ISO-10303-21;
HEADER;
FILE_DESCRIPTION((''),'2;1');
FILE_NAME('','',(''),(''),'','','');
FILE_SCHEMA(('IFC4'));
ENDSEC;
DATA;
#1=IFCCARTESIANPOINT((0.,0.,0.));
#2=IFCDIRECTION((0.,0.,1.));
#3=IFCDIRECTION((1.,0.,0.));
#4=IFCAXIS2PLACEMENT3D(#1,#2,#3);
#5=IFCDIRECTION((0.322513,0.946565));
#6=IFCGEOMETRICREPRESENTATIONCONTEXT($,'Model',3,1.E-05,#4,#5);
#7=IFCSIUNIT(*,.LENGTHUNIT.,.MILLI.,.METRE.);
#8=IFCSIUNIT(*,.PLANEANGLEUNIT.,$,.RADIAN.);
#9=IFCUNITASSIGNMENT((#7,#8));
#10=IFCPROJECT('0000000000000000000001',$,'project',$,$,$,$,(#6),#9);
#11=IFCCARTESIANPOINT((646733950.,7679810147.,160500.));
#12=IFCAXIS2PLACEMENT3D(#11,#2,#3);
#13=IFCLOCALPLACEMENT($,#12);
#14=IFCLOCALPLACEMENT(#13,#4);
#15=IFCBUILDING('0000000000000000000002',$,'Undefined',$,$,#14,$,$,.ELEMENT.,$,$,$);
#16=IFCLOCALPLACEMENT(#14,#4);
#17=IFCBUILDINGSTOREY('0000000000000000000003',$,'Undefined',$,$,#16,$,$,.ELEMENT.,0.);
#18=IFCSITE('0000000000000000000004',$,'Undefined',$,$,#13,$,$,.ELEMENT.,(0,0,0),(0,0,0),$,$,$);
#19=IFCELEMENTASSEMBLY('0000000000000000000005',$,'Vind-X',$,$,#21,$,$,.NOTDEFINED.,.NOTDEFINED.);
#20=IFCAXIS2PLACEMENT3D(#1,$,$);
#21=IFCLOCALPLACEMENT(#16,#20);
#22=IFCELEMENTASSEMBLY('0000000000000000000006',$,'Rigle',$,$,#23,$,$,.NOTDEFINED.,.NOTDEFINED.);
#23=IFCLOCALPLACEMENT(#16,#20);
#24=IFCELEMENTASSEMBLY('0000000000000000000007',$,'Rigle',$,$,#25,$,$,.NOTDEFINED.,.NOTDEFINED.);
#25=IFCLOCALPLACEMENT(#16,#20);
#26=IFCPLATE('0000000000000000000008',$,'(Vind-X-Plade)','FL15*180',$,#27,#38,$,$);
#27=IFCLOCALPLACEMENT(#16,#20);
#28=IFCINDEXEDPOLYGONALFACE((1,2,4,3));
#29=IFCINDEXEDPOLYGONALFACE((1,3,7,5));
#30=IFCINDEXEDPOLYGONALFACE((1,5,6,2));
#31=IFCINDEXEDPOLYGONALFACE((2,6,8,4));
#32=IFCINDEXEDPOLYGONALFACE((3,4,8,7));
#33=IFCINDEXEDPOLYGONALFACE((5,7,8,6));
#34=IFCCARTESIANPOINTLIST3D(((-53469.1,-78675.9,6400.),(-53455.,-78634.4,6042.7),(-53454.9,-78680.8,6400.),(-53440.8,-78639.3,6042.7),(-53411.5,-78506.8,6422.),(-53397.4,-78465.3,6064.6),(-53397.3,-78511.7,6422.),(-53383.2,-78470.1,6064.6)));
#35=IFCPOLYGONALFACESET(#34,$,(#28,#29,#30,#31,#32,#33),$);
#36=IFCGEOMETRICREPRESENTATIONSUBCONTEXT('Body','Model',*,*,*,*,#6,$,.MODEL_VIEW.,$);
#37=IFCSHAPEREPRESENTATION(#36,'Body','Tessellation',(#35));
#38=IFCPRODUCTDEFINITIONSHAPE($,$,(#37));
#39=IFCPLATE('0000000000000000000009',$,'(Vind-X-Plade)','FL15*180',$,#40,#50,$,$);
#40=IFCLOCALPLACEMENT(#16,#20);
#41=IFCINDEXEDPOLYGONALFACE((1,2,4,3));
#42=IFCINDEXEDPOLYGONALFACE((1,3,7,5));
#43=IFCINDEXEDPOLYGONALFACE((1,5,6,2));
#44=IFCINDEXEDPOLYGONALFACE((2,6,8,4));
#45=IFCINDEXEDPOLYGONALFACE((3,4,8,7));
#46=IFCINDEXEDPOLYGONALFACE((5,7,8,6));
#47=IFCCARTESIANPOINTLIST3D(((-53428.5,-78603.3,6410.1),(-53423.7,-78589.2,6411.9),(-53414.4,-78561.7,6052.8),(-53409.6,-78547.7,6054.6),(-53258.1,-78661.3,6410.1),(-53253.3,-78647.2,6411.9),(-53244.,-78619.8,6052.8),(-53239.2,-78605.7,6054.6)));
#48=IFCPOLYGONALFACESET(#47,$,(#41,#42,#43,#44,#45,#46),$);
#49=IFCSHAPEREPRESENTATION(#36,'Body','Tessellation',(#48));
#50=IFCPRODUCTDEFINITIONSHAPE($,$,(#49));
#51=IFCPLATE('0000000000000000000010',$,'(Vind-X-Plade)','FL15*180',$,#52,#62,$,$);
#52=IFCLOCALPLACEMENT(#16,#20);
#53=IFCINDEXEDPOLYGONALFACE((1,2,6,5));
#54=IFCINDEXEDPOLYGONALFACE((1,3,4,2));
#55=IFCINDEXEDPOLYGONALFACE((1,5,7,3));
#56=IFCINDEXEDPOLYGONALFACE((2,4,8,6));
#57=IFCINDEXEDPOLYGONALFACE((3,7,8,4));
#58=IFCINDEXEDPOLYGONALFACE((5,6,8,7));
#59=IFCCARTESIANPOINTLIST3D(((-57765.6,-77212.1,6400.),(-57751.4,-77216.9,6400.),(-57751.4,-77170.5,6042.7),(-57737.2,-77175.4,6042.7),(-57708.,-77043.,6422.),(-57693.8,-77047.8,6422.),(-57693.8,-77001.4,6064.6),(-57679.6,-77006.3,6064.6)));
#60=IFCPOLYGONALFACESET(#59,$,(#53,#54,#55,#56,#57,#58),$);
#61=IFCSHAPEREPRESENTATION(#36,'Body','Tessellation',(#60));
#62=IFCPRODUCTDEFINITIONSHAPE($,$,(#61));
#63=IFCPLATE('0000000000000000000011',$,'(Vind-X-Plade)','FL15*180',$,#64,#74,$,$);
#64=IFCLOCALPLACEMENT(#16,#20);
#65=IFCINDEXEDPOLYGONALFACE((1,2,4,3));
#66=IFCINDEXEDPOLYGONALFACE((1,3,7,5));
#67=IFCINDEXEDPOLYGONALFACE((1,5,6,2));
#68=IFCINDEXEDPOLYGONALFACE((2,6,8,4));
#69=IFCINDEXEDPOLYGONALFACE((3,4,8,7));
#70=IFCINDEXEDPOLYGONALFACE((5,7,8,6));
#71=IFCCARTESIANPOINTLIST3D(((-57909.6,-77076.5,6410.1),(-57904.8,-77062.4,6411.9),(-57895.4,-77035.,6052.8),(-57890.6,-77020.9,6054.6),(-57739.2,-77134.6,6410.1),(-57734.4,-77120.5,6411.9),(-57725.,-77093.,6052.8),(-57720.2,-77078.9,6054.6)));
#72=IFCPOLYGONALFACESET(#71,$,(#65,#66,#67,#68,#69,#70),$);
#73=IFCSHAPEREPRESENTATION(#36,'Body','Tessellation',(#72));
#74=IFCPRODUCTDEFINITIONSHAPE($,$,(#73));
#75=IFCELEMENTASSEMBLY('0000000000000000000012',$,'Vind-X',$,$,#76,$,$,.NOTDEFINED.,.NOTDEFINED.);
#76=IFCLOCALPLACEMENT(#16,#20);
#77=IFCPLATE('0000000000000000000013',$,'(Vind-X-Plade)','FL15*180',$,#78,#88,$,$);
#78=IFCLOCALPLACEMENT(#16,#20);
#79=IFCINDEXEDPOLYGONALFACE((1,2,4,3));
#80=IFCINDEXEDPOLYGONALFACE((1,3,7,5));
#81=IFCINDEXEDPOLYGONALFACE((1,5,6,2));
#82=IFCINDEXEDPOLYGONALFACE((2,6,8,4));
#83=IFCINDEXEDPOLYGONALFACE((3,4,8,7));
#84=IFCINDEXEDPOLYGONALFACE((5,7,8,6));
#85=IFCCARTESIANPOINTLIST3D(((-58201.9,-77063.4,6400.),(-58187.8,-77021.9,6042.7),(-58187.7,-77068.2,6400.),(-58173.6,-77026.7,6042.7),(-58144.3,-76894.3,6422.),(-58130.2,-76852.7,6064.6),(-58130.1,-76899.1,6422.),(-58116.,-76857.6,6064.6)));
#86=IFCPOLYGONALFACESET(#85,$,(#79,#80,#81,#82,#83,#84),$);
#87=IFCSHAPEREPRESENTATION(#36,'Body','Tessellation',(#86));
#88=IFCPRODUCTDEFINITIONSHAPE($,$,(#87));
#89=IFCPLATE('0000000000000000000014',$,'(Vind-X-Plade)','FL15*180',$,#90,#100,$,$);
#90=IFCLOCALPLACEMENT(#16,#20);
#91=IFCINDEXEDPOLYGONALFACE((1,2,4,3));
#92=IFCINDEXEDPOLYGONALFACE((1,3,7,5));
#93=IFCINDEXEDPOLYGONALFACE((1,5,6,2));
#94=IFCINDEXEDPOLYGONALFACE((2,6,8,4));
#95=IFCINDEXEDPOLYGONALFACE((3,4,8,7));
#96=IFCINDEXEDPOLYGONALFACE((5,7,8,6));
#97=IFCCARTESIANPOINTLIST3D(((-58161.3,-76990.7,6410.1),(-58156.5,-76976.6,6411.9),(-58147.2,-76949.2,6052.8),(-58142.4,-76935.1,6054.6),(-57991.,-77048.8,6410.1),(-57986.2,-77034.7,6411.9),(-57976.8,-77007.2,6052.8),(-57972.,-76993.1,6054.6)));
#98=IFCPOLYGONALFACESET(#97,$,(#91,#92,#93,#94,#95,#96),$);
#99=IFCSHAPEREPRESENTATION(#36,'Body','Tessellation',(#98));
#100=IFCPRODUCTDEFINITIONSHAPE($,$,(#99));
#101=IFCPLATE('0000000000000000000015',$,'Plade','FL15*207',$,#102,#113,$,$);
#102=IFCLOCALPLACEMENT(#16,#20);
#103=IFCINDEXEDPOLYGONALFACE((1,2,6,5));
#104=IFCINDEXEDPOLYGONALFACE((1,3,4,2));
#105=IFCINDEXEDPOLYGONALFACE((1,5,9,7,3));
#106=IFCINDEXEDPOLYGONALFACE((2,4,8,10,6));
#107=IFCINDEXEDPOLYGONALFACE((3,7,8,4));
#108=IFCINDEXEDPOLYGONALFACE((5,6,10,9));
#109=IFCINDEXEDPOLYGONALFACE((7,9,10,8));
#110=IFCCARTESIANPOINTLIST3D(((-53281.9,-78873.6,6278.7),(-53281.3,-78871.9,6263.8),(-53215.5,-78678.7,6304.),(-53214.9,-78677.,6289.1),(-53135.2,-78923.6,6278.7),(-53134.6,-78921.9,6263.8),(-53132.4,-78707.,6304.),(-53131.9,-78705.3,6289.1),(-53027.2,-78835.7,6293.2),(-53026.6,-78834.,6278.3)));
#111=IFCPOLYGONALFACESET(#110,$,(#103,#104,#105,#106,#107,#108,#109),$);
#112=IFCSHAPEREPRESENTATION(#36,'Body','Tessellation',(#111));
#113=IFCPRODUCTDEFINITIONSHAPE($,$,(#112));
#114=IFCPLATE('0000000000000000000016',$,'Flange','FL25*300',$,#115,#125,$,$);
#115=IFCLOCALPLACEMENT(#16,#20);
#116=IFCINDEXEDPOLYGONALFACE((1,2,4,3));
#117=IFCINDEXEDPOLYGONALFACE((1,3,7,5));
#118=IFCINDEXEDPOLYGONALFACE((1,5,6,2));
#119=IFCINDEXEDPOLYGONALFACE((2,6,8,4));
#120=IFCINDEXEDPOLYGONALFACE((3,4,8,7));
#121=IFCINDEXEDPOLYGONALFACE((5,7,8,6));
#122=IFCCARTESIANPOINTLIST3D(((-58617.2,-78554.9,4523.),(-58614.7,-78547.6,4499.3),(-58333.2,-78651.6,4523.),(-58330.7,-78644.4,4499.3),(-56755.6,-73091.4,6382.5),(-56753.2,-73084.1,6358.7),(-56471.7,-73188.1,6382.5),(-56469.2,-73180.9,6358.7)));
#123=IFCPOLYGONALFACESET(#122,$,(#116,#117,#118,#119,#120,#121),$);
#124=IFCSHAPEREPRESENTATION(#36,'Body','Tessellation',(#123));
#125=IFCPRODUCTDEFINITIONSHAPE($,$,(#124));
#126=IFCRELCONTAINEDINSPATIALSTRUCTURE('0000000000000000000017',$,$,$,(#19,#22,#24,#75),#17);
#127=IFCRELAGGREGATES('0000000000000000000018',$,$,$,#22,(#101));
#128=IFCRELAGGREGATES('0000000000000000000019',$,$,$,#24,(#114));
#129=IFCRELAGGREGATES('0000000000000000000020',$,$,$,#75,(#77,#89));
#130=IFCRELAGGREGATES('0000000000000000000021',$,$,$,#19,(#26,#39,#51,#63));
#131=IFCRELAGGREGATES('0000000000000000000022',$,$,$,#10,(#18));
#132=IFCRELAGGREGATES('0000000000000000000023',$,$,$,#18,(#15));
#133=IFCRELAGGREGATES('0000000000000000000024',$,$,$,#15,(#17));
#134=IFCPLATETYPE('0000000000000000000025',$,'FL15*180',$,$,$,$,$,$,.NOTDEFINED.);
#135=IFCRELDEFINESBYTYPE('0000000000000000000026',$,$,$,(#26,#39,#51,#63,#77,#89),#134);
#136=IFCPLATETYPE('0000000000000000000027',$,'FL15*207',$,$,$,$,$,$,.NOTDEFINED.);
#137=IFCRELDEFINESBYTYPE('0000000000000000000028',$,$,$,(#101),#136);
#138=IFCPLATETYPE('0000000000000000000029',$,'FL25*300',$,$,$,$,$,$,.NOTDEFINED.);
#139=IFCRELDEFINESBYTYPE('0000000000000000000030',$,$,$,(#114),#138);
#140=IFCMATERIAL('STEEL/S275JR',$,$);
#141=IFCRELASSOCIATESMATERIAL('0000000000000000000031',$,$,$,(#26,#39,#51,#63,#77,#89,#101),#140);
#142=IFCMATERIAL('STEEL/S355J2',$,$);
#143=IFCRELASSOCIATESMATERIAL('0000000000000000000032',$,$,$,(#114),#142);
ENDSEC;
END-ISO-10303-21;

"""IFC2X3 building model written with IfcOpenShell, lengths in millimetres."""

from ifc_helpers import new_model, si_unit, direction, frame, origin_with_axes, place, context, subcontext, project, spatial, polyline, outline, extrude, clip, halfspace, material, type_object, element, aggregate, save


model = new_model("IFC2X3")

# Units and contexts
model_context = context("Model", 3, precision=1e-05, world=origin_with_axes(), true_north=direction((0.322513, 0.946565)))
body_context = subcontext(model_context, "Body", "Model", "MODEL_VIEW")
ifc_project = project(units=[si_unit("LENGTHUNIT", "METRE", prefix="MILLI"), si_unit("PLANEANGLEUNIT", "RADIAN")], contexts=[model_context])

# Site, building, storey
site_placement = place(None, frame((646733950.0, 7679810147.0, 160500.0), z_axis=(0.0, 0.0, 1.0), x_axis=(1.0, 0.0, 0.0)))
site = spatial("IfcSite", under=ifc_project, at=site_placement, Name="Undefined", CompositionType="ELEMENT", RefLatitude=(0, 0, 0), RefLongitude=(0, 0, 0))
building_placement = place(site_placement, origin_with_axes())
building = spatial("IfcBuilding", under=site, at=building_placement, Name="Undefined", CompositionType="ELEMENT")
storey_placement = place(building_placement, origin_with_axes())
storey = spatial("IfcBuildingStorey", under=building, at=storey_placement, Name="Undefined", CompositionType="ELEMENT", Elevation=0.0)

# Shared definitions
ifc_material_1 = material(Name="STEEL/S355J2")

# Element assembly
assembly_1_placement = place(storey_placement, origin_with_axes())
assembly_1 = element("IfcElementAssembly", 1, at=assembly_1_placement, inside=storey, Name="Vind-X", AssemblyPlace="NOTDEFINED", PredefinedType="NOTDEFINED")

# Shared definitions
ifc_material_2 = material(Name="STEEL/S275JR")

# Element assemblies
assembly_2_placement = place(storey_placement, origin_with_axes())
assembly_2 = element("IfcElementAssembly", 2, at=assembly_2_placement, inside=storey, Name="Rigle", AssemblyPlace="NOTDEFINED", PredefinedType="NOTDEFINED")
assembly_3_placement = place(storey_placement, origin_with_axes())
assembly_3 = element("IfcElementAssembly", 3, at=assembly_3_placement, inside=storey, Name="Rigle", AssemblyPlace="NOTDEFINED", PredefinedType="NOTDEFINED")

# Shared definitions
plate_type_1 = type_object("IfcPlateType", Name="FL15*180", PredefinedType="NOTDEFINED")

# Plates
plate_1_placement = place(assembly_1_placement, frame((-53404.4, -78509.3, 6422.0), z_axis=(0.946565, -0.322513, 0.0), x_axis=(-0.320109, -0.93951, -0.121869)))
plate_1 = element("IfcPlate", 4, at=plate_1_placement, type_object=plate_type_1, material=ifc_material_2, Name="(Vind-X-Plade)", Description="FL15*180", context=body_context, shape_type="SweptSolid", body=[
    extrude(outline(polyline([(0.0, 0.0), (180.0, 0.0), (180.0, 360.0), (0.0, 360.0), (0.0, 0.0)])), frame((0.0, 0.0, -7.5), z_axis=(0.0, 0.0, 1.0), x_axis=(1.0, 0.0, 0.0)), (0.0, 0.0, 1.0), 15.0),
])
plate_2_placement = place(assembly_1_placement, frame((-53241.6, -78612.8, 6053.7), z_axis=(-0.320109, -0.93951, -0.121869), x_axis=(-0.039304, -0.115357, 0.992546)))
plate_2 = element("IfcPlate", 5, at=plate_2_placement, type_object=plate_type_1, material=ifc_material_2, Name="(Vind-X-Plade)", Description="FL15*180", context=body_context, shape_type="SweptSolid", body=[
    extrude(outline(polyline([(0.0, 0.0), (360.0, 0.0), (360.0, 180.0), (0.0, 180.0), (0.0, 0.0)])), frame((0.0, 0.0, -7.5), z_axis=(0.0, 0.0, 1.0), x_axis=(1.0, 0.0, 0.0)), (0.0, 0.0, 1.0), 15.0),
])
plate_3_placement = place(assembly_1_placement, frame((-57758.5, -77214.5, 6400.0), z_axis=(-0.946565, 0.322513, 0.0), x_axis=(0.320109, 0.93951, 0.121869)))
plate_3 = element("IfcPlate", 6, at=plate_3_placement, type_object=plate_type_1, material=ifc_material_2, Name="(Vind-X-Plade)", Description="FL15*180", context=body_context, shape_type="SweptSolid", body=[
    extrude(outline(polyline([(0.0, 0.0), (180.0, 0.0), (180.0, 360.0), (0.0, 360.0), (0.0, 0.0)])), frame((0.0, 0.0, -7.5), z_axis=(0.0, 0.0, 1.0), x_axis=(1.0, 0.0, 0.0)), (0.0, 0.0, 1.0), 15.0),
])
plate_4_placement = place(assembly_1_placement, frame((-57893.0, -77027.9, 6053.7), z_axis=(0.320109, 0.93951, 0.121869), x_axis=(-0.039304, -0.115357, 0.992546)))
plate_4 = element("IfcPlate", 7, at=plate_4_placement, type_object=plate_type_1, material=ifc_material_2, Name="(Vind-X-Plade)", Description="FL15*180", context=body_context, shape_type="SweptSolid", body=[
    extrude(outline(polyline([(0.0, 0.0), (360.0, 0.0), (360.0, 180.0), (0.0, 180.0), (0.0, 0.0)])), frame((0.0, 0.0, -7.5), z_axis=(0.0, 0.0, 1.0), x_axis=(1.0, 0.0, 0.0)), (0.0, 0.0, 1.0), 15.0),
])

# Element assembly, plates
assembly_4_placement = place(storey_placement, origin_with_axes())
assembly_4 = element("IfcElementAssembly", 8, at=assembly_4_placement, inside=storey, Name="Vind-X", AssemblyPlace="NOTDEFINED", PredefinedType="NOTDEFINED")
plate_5_placement = place(assembly_4_placement, frame((-58137.2, -76896.7, 6422.0), z_axis=(0.946565, -0.322513, 0.0), x_axis=(-0.320109, -0.93951, -0.121869)))
plate_5 = element("IfcPlate", 9, at=plate_5_placement, type_object=plate_type_1, material=ifc_material_2, Name="(Vind-X-Plade)", Description="FL15*180", context=body_context, shape_type="SweptSolid", body=[
    extrude(outline(polyline([(0.0, 0.0), (180.0, 0.0), (180.0, 360.0), (0.0, 360.0), (0.0, 0.0)])), frame((0.0, 0.0, -7.5), z_axis=(0.0, 0.0, 1.0), x_axis=(1.0, 0.0, 0.0)), (0.0, 0.0, 1.0), 15.0),
])
plate_6_placement = place(assembly_4_placement, frame((-57974.4, -77000.2, 6053.7), z_axis=(-0.320109, -0.93951, -0.121869), x_axis=(-0.039304, -0.115357, 0.992546)))
plate_6 = element("IfcPlate", 10, at=plate_6_placement, type_object=plate_type_1, material=ifc_material_2, Name="(Vind-X-Plade)", Description="FL15*180", context=body_context, shape_type="SweptSolid", body=[
    extrude(outline(polyline([(0.0, 0.0), (360.0, 0.0), (360.0, 180.0), (0.0, 180.0), (0.0, 0.0)])), frame((0.0, 0.0, -7.5), z_axis=(0.0, 0.0, 1.0), x_axis=(1.0, 0.0, 0.0)), (0.0, 0.0, 1.0), 15.0),
])

# Plates
plate_type_2 = type_object("IfcPlateType", Name="FL15*207", PredefinedType="NOTDEFINED")
plate_7_placement = place(assembly_2_placement, frame((-53215.2, -78677.8, 6296.5), z_axis=(-0.039304, -0.115357, 0.992546), x_axis=(-0.320109, -0.93951, -0.121869)))
plate_7 = element("IfcPlate", 11, at=plate_7_placement, type_object=plate_type_2, material=ifc_material_2, Name="Plade", Description="FL15*207", context=body_context, shape_type="SweptSolid", body=[
    extrude(outline(polyline([(0.0, 0.0), (207.5, 0.0), (207.5, 154.9), (88.6, 228.8), (0.0, 87.7), (0.0, 0.0)])), frame((0.0, 0.0, -7.5), z_axis=(0.0, 0.0, 1.0), x_axis=(1.0, 0.0, 0.0)), (0.0, 0.0, 1.0), 15.0),
])
aggregate(assembly_2, [plate_7])
plate_type_3 = type_object("IfcPlateType", Name="FL25*300", PredefinedType="NOTDEFINED")
plate_8_placement = place(assembly_3_placement, frame((-58473.9, -78599.6, 4511.2), z_axis=(0.098895, 0.290253, -0.951826), x_axis=(0.306976, 0.900965, 0.306638)))
plate_8 = element("IfcPlate", 12, at=plate_8_placement, type_object=plate_type_3, material=ifc_material_1, Name="Flange", Description="FL25*300", context=body_context, shape_type="Clipping", body=[
    clip(extrude(outline(polyline([(0.0, -150.0), (0.0, 150.0), (6064.1, 150.0), (6064.1, -150.0), (0.0, -150.0)])), frame((0.0, 0.0, -12.5), z_axis=(0.0, 0.0, 1.0), x_axis=(1.0, 0.0, 0.0)), (0.0, 0.0, 1.0), 25.0), halfspace(frame((6064.1, 0.0, 0.3), z_axis=(1.0, 0.0, 0.0), x_axis=(0.0, 1.0, 0.0)), False)),
])
aggregate(assembly_3, [plate_8])

aggregate(assembly_4, [plate_5, plate_6])
aggregate(assembly_1, [plate_1, plate_2, plate_3, plate_4])

save(model, "model.ifc")
